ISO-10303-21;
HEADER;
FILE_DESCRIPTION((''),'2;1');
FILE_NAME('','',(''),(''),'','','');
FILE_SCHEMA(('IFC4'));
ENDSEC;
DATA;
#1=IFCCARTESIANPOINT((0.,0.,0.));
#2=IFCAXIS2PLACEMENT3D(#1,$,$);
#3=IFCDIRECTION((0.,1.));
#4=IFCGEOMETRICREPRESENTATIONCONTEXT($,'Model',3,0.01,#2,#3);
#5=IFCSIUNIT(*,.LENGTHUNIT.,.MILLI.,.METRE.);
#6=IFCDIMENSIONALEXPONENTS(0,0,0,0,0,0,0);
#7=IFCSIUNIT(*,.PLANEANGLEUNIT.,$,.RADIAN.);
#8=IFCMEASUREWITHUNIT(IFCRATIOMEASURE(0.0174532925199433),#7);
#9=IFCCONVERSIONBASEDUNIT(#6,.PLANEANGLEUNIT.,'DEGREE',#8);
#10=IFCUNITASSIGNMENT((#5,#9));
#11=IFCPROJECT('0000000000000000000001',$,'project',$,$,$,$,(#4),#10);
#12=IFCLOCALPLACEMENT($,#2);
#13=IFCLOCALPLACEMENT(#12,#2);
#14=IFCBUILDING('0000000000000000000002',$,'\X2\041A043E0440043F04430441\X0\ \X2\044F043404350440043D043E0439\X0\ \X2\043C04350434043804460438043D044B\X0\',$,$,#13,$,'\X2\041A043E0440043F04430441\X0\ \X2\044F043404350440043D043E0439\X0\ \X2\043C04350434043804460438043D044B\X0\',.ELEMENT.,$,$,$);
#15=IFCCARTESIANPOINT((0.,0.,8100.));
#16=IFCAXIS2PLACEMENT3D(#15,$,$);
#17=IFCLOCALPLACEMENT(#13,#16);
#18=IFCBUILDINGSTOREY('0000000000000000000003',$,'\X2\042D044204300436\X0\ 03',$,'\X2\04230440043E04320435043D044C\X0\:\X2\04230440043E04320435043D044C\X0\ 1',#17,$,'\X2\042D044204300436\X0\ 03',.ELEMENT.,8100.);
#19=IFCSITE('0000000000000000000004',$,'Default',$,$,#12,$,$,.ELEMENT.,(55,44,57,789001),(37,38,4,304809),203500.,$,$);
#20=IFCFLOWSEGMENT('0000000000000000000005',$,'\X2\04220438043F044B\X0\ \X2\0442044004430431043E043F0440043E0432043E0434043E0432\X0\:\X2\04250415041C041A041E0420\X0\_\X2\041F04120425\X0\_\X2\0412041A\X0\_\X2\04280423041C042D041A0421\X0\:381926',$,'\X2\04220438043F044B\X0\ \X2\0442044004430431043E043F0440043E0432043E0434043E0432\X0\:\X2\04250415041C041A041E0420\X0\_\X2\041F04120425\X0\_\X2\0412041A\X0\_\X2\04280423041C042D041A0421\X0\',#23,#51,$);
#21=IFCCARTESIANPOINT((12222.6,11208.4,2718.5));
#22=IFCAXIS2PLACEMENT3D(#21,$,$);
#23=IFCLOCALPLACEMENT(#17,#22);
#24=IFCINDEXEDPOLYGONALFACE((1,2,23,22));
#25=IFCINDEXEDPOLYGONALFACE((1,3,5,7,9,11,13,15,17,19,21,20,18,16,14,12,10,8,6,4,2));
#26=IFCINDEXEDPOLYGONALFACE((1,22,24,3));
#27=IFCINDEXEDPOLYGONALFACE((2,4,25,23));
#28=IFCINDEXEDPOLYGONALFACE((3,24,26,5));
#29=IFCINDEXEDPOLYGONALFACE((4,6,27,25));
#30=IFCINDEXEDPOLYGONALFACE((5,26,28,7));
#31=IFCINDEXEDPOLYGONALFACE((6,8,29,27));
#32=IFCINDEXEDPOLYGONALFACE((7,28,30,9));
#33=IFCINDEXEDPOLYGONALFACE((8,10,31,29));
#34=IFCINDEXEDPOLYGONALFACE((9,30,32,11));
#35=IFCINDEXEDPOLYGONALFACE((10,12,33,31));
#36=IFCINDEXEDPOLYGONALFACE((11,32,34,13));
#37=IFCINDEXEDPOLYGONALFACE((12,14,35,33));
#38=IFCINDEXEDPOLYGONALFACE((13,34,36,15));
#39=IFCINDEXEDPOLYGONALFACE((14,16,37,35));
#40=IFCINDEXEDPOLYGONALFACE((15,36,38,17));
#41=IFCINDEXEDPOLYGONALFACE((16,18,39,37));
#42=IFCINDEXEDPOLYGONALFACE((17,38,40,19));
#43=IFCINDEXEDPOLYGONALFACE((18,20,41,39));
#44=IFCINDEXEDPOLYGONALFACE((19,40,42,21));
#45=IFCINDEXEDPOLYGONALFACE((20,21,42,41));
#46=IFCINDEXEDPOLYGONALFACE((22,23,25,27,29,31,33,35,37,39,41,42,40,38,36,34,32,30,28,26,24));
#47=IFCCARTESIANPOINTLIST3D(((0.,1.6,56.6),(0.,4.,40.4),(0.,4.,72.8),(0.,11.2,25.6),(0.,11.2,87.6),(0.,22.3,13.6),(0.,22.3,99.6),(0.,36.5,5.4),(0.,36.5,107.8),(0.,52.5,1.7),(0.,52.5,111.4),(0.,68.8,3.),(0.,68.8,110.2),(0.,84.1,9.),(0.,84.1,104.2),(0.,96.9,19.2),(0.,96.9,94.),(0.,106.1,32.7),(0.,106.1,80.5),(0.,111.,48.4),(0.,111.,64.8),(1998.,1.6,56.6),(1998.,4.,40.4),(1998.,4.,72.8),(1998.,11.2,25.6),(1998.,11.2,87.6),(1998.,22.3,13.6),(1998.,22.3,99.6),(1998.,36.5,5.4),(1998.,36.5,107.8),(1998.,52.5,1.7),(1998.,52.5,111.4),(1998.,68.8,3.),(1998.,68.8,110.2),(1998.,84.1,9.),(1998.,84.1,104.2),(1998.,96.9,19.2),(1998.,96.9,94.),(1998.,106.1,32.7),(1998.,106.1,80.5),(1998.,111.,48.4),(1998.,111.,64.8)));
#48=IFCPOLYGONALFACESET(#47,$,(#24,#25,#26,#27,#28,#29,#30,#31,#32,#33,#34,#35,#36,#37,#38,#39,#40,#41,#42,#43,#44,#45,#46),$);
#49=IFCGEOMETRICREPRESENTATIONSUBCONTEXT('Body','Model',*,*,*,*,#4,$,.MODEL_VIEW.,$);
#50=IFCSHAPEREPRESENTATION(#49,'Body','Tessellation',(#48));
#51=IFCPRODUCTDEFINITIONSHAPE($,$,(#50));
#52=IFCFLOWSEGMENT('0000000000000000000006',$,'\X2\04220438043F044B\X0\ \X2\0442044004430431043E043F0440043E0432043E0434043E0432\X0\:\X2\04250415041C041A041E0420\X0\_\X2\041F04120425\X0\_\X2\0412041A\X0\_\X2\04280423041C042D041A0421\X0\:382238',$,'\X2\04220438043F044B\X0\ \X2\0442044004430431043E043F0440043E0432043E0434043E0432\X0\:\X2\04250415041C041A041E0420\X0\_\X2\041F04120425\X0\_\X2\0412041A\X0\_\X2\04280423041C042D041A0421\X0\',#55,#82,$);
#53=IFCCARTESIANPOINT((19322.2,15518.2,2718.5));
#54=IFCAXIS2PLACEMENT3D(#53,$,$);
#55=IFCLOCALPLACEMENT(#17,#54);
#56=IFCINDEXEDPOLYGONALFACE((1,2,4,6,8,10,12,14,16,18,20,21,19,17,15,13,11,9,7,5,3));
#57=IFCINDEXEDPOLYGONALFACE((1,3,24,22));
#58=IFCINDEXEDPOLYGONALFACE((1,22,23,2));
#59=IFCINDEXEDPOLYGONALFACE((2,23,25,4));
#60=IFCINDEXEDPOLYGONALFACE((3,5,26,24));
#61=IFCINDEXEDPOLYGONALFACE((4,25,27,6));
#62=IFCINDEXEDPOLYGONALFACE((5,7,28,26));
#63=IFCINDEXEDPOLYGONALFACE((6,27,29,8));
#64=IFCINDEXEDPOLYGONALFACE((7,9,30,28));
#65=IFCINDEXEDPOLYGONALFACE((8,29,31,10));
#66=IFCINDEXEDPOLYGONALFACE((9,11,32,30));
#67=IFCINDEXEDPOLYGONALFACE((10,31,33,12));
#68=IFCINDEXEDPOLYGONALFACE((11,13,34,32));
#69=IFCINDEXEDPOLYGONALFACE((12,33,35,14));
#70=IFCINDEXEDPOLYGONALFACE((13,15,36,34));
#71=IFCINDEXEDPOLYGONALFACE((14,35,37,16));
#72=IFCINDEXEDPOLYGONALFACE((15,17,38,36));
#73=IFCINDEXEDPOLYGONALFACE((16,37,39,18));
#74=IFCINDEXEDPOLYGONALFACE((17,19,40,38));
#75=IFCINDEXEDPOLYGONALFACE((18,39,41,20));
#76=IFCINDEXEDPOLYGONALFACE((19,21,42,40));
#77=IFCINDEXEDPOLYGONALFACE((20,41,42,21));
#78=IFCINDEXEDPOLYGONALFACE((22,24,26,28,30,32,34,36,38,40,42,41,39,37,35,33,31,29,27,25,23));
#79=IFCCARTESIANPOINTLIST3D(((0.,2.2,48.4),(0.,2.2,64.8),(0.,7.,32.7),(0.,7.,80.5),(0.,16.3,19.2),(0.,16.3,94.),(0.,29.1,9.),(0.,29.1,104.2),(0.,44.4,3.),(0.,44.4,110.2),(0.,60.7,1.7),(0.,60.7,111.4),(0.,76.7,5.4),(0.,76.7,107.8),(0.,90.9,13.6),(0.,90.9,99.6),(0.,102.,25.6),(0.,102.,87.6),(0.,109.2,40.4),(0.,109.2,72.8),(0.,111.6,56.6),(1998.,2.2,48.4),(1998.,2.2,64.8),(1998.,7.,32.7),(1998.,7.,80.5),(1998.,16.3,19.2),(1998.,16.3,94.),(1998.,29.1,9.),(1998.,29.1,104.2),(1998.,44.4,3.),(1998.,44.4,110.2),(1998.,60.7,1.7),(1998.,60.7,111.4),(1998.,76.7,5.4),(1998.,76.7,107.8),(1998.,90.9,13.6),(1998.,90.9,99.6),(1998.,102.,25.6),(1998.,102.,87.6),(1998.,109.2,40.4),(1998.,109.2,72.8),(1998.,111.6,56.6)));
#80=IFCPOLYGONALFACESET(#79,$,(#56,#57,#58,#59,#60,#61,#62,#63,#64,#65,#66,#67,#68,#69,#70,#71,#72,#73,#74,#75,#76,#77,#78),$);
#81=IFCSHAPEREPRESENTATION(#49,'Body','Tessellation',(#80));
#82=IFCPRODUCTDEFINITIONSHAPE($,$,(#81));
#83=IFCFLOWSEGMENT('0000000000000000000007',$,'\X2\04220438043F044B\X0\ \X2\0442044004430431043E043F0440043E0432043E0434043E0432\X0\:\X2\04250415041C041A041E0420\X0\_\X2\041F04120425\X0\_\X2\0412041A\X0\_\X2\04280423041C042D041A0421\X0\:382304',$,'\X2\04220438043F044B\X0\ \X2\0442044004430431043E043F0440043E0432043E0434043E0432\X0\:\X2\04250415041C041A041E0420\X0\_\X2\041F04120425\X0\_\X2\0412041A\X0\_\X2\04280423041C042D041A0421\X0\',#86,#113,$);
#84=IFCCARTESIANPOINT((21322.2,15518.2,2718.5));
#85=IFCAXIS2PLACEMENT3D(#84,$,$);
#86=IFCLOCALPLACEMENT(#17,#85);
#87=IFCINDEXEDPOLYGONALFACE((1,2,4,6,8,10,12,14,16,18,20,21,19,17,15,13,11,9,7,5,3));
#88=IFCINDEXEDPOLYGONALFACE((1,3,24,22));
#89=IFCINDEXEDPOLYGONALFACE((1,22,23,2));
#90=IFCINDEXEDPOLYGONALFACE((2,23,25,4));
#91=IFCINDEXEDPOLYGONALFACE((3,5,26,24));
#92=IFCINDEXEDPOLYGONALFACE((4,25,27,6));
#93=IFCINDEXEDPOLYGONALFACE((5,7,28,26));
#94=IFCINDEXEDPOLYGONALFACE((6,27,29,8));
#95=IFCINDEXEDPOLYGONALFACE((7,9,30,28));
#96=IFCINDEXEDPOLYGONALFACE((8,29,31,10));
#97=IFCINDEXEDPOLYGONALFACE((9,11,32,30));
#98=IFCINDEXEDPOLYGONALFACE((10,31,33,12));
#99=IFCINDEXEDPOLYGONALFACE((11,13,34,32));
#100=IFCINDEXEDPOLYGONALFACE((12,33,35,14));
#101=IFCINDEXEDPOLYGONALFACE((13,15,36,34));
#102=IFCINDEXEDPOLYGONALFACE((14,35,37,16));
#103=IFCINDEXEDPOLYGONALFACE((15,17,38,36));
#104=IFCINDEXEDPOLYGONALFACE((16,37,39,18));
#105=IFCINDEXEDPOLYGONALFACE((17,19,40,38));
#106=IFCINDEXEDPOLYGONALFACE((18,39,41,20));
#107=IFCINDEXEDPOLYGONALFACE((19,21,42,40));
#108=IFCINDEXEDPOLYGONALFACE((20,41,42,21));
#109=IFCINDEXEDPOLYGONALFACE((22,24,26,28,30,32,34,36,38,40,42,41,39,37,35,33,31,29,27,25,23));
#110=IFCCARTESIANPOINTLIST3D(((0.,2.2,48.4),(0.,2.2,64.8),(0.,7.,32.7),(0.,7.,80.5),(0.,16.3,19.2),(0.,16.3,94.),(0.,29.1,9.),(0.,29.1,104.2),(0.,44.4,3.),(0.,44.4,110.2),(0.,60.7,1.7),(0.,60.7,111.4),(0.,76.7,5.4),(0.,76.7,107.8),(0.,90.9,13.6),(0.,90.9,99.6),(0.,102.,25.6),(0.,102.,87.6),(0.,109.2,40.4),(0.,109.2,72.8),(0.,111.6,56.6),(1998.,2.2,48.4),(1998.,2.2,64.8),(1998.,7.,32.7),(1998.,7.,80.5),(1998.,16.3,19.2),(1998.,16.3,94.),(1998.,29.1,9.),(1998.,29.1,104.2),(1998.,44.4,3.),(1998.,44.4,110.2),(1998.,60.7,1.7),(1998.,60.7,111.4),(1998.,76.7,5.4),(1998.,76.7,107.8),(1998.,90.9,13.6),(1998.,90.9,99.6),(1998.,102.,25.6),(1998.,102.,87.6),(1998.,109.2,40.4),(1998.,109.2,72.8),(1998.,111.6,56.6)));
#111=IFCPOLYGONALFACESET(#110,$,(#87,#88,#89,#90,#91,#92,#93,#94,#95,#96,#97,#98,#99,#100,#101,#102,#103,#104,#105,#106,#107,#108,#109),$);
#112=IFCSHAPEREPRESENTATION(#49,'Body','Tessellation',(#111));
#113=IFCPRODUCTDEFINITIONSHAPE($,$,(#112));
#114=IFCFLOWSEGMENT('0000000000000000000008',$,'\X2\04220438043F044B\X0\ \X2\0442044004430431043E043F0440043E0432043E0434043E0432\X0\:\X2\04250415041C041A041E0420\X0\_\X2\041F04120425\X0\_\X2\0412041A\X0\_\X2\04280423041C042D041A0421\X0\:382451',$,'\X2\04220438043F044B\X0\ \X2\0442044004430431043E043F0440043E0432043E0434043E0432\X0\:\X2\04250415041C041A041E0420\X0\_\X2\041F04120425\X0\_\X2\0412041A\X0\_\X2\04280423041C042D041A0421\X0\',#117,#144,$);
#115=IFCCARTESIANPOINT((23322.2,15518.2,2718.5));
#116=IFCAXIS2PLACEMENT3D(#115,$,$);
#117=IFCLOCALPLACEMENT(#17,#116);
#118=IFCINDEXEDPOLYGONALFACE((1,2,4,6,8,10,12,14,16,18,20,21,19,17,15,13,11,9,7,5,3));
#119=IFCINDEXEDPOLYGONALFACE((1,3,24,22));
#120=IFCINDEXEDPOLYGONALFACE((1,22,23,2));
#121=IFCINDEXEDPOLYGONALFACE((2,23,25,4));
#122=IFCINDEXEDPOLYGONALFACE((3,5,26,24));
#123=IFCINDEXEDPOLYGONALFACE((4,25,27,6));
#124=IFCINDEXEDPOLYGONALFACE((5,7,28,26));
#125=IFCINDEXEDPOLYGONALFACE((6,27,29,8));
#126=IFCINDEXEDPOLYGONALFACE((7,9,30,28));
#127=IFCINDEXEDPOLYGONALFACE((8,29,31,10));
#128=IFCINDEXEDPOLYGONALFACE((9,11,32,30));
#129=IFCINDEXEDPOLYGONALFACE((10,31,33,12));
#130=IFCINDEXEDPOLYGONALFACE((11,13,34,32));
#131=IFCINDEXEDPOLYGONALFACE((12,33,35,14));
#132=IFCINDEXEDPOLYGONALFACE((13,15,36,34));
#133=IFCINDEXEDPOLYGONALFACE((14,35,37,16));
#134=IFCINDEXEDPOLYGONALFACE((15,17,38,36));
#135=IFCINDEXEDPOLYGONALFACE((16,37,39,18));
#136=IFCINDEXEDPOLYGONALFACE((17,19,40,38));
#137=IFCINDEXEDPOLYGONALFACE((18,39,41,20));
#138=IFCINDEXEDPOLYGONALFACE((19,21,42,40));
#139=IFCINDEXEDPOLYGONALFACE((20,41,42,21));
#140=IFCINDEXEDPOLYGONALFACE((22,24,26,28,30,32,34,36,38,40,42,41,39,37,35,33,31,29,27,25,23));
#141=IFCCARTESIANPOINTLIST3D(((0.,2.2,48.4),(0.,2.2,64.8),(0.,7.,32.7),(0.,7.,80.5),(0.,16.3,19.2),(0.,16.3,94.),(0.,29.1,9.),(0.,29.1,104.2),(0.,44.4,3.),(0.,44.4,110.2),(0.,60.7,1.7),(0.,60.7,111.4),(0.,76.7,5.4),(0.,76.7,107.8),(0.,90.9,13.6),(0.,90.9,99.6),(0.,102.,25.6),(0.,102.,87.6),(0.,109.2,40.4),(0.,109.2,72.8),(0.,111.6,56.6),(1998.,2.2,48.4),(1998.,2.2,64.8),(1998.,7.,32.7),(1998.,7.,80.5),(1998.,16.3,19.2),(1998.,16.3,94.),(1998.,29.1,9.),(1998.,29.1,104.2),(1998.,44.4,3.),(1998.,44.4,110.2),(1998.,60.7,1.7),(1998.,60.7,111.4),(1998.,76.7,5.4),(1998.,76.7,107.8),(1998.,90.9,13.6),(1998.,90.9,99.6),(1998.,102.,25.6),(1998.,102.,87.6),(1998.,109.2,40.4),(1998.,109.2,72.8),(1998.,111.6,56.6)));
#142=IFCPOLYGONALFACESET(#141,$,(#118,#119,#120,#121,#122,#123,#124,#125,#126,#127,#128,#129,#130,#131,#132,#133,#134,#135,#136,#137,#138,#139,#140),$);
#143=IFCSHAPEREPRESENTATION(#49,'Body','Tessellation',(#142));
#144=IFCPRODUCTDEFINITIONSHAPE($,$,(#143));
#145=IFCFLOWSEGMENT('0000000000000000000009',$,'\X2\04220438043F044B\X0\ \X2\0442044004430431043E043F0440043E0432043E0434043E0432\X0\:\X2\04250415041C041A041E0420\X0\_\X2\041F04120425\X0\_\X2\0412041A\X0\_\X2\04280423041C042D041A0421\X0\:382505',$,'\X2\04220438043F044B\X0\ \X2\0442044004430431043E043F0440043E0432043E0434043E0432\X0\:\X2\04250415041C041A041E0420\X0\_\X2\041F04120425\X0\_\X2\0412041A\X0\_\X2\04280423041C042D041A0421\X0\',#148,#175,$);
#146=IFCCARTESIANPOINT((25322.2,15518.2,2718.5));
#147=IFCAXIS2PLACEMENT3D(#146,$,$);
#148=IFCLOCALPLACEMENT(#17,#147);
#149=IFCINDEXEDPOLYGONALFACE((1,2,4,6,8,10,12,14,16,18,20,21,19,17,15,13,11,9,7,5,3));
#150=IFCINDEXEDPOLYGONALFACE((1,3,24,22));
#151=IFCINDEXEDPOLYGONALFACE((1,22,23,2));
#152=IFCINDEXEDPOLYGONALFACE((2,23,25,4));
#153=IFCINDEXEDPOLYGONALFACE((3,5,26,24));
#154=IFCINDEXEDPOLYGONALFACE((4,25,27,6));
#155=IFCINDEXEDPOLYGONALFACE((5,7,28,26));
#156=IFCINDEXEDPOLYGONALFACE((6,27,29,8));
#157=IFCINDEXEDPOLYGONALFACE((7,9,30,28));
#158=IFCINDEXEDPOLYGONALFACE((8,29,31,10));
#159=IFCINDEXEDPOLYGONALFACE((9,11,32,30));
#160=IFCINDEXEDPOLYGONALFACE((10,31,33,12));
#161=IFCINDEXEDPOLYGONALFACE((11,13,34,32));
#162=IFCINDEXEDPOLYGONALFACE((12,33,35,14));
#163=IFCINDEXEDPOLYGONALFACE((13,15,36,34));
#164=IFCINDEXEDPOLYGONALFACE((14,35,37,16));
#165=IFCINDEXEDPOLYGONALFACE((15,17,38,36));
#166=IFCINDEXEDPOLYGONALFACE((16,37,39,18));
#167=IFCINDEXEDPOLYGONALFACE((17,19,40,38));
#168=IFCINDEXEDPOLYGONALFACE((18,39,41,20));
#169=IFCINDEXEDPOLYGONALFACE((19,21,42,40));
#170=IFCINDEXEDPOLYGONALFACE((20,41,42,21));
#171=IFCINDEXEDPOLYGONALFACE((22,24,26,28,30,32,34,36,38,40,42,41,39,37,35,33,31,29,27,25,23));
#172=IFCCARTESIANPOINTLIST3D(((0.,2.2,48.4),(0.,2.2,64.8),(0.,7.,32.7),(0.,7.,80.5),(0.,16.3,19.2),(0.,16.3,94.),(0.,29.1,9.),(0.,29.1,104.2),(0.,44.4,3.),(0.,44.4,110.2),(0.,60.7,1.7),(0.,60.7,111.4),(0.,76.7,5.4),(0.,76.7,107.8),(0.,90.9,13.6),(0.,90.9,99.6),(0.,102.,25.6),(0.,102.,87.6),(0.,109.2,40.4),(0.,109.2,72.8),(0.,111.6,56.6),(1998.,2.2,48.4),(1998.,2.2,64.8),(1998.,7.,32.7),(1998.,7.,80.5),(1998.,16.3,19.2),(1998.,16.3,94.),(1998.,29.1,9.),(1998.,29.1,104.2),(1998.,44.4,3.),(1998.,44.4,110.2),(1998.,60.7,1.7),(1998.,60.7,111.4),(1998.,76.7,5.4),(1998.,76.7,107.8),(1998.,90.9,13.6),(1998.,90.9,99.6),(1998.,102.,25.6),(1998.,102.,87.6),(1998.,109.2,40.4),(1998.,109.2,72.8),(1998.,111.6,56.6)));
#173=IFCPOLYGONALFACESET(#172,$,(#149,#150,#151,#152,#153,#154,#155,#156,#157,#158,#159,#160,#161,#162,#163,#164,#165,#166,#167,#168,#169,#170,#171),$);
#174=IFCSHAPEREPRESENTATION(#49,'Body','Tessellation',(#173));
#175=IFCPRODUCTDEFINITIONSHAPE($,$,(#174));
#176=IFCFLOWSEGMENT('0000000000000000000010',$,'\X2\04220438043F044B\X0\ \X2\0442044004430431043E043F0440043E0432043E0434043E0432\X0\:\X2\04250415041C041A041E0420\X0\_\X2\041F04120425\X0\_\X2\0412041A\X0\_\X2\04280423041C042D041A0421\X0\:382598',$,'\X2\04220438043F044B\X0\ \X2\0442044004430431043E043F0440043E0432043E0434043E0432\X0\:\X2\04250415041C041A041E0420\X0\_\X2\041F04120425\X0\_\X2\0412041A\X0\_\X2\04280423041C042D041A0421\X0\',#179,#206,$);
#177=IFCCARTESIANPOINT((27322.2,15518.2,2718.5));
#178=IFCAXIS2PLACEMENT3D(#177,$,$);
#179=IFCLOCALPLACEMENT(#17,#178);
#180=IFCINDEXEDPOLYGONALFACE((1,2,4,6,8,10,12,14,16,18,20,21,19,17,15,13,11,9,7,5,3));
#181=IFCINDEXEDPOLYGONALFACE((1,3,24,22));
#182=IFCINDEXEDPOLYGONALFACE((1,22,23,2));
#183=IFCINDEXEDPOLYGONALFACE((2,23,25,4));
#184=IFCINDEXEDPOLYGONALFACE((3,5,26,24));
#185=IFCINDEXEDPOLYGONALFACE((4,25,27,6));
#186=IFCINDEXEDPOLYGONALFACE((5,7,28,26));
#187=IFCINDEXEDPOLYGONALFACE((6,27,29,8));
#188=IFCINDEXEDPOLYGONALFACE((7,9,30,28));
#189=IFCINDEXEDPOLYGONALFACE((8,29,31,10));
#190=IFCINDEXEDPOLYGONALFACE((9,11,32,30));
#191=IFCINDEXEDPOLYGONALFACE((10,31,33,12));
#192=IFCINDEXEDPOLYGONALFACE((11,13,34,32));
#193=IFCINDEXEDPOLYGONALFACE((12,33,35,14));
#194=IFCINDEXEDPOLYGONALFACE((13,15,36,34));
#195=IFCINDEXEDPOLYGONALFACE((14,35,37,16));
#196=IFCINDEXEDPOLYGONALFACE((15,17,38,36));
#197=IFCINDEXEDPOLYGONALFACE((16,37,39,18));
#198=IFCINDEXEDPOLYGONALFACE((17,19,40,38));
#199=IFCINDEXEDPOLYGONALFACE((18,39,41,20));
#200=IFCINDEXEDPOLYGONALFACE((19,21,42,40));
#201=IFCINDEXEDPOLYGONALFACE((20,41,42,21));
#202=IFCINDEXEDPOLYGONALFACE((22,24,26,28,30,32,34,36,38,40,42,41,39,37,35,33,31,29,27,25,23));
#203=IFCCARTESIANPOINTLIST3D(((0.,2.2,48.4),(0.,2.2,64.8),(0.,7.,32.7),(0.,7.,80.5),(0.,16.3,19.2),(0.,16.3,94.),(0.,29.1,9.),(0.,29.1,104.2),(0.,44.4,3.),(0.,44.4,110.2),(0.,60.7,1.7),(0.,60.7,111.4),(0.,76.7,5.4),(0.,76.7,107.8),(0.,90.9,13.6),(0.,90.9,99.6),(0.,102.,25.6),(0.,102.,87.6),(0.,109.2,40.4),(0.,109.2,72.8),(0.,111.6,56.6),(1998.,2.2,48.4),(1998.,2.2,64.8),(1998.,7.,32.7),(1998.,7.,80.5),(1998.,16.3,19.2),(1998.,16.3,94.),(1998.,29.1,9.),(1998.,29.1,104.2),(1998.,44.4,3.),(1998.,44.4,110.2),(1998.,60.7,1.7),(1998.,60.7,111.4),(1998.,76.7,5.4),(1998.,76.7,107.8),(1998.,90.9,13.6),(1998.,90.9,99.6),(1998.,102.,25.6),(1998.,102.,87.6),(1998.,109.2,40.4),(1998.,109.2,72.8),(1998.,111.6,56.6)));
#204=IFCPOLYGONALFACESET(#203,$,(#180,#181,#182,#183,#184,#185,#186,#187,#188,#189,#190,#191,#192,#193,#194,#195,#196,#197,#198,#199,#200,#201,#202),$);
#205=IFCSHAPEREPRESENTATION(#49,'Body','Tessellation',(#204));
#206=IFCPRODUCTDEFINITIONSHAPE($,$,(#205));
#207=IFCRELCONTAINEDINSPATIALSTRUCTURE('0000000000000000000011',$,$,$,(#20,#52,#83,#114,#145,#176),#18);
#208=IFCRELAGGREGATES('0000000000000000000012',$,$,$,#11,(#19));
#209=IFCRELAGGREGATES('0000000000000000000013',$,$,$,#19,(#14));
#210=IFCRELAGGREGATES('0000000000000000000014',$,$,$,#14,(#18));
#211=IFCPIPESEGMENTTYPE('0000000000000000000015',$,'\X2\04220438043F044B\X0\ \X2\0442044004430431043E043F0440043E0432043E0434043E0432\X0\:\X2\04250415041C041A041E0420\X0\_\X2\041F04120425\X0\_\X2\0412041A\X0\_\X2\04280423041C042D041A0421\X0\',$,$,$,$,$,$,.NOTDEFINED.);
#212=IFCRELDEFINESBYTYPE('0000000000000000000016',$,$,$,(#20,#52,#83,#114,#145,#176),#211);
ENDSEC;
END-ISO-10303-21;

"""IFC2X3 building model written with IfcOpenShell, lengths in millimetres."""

from ifc_helpers import new_model, entity, si_unit, converted_unit, direction, frame, frame_2d, origin, origin_2d_with_axis, place, context, subcontext, project, spatial, circle, extrude, type_object, element, save


model = new_model("IFC2X3")

# Units and contexts
model_context = context("Model", 3, precision=0.01, world=origin(), true_north=direction((0.0, 1.0)))
body_context = subcontext(model_context, "Body", "Model", "MODEL_VIEW")
ifc_project = project(units=[si_unit("LENGTHUNIT", "METRE", prefix="MILLI"), converted_unit("PLANEANGLEUNIT", "DEGREE", entity("IfcRatioMeasure", 0.0174532925199433), si_unit("PLANEANGLEUNIT", "RADIAN"), dimensions=[0, 0, 0, 0, 0, 0, 0])], contexts=[model_context])

# Site, building, storey
site_placement = place(None, frame((0.0, 0.0, 0.0)))
site = spatial("IfcSite", under=ifc_project, at=site_placement, Name="Default", CompositionType="ELEMENT", RefLatitude=(55, 44, 57, 789001), RefLongitude=(37, 38, 4, 304809), RefElevation=203500.0)
building_placement = place(site_placement, origin())
building = spatial("IfcBuilding", under=site, at=building_placement, Name="Корпус ядерной медицины", LongName="Корпус ядерной медицины", CompositionType="ELEMENT")
storey_placement = place(building_placement, frame((0.0, 0.0, 8100.0)))
storey = spatial("IfcBuildingStorey", under=building, at=storey_placement, Name="Этаж 03", ObjectType="Уровень:Уровень 1", LongName="Этаж 03", CompositionType="ELEMENT", Elevation=8100.0)

# Flow segments
pipe_segment_type = type_object("IfcPipeSegmentType", Name="Типы трубопроводов:ХЕМКОР_ПВХ_ВК_ШУМЭКС", PredefinedType="NOTDEFINED")
for number, where, name in (
    (1, (12222.6, 11208.4, 2718.5), "Типы трубопроводов:ХЕМКОР_ПВХ_ВК_ШУМЭКС:381926"),
):
    element("IfcFlowSegment", number, at=place(storey_placement, frame(where)), inside=storey, type_object=pipe_segment_type, Name=name, ObjectType="Типы трубопроводов:ХЕМКОР_ПВХ_ВК_ШУМЭКС", context=body_context, shape_type="SweptSolid", body=[
        extrude(circle(Radius=55.0, at=origin_2d_with_axis()), frame((0.0, 56.6, 56.6), z_axis=(1.0, 0.0, 0.0), x_axis=(0.0, -1.0, 0.0)), (0.0, 0.0, 1.0), 1998.0),
    ])
flow_segment_1_placement = place(storey_placement, frame((19322.2, 15518.2, 2718.5)))
element("IfcFlowSegment", 2, at=flow_segment_1_placement, inside=storey, type_object=pipe_segment_type, Name="Типы трубопроводов:ХЕМКОР_ПВХ_ВК_ШУМЭКС:382238", ObjectType="Типы трубопроводов:ХЕМКОР_ПВХ_ВК_ШУМЭКС", context=body_context, shape_type="SweptSolid", body=[
    extrude(circle(Radius=55.0, at=frame_2d((0.0, 0.0), x_axis=(1.0, 0.0))), frame((0.0, 56.6, 56.6), z_axis=(1.0, 0.0, 0.0), x_axis=(0.0, 1.0, 0.0)), (0.0, 0.0, 1.0), 1998.0),
])
flow_segment_2_placement = place(storey_placement, frame((21322.2, 15518.2, 2718.5)))
element("IfcFlowSegment", 3, at=flow_segment_2_placement, inside=storey, type_object=pipe_segment_type, Name="Типы трубопроводов:ХЕМКОР_ПВХ_ВК_ШУМЭКС:382304", ObjectType="Типы трубопроводов:ХЕМКОР_ПВХ_ВК_ШУМЭКС", context=body_context, shape_type="SweptSolid", body=[
    extrude(circle(Radius=55.0, at=frame_2d((0.0, 0.0), x_axis=(1.0, 0.0))), frame((0.0, 56.6, 56.6), z_axis=(1.0, 0.0, 0.0), x_axis=(0.0, 1.0, 0.0)), (0.0, 0.0, 1.0), 1998.0),
])
flow_segment_3_placement = place(storey_placement, frame((23322.2, 15518.2, 2718.5)))
element("IfcFlowSegment", 4, at=flow_segment_3_placement, inside=storey, type_object=pipe_segment_type, Name="Типы трубопроводов:ХЕМКОР_ПВХ_ВК_ШУМЭКС:382451", ObjectType="Типы трубопроводов:ХЕМКОР_ПВХ_ВК_ШУМЭКС", context=body_context, shape_type="SweptSolid", body=[
    extrude(circle(Radius=55.0, at=frame_2d((0.0, 0.0), x_axis=(1.0, 0.0))), frame((0.0, 56.6, 56.6), z_axis=(1.0, 0.0, 0.0), x_axis=(0.0, 1.0, 0.0)), (0.0, 0.0, 1.0), 1998.0),
])
flow_segment_4_placement = place(storey_placement, frame((25322.2, 15518.2, 2718.5)))
element("IfcFlowSegment", 5, at=flow_segment_4_placement, inside=storey, type_object=pipe_segment_type, Name="Типы трубопроводов:ХЕМКОР_ПВХ_ВК_ШУМЭКС:382505", ObjectType="Типы трубопроводов:ХЕМКОР_ПВХ_ВК_ШУМЭКС", context=body_context, shape_type="SweptSolid", body=[
    extrude(circle(Radius=55.0, at=frame_2d((0.0, 0.0), x_axis=(1.0, 0.0))), frame((0.0, 56.6, 56.6), z_axis=(1.0, 0.0, 0.0), x_axis=(0.0, 1.0, 0.0)), (0.0, 0.0, 1.0), 1998.0),
])
flow_segment_5_placement = place(storey_placement, frame((27322.2, 15518.2, 2718.5)))
element("IfcFlowSegment", 6, at=flow_segment_5_placement, inside=storey, type_object=pipe_segment_type, Name="Типы трубопроводов:ХЕМКОР_ПВХ_ВК_ШУМЭКС:382598", ObjectType="Типы трубопроводов:ХЕМКОР_ПВХ_ВК_ШУМЭКС", context=body_context, shape_type="SweptSolid", body=[
    extrude(circle(Radius=55.0, at=frame_2d((0.0, 0.0), x_axis=(1.0, 0.0))), frame((0.0, 56.6, 56.6), z_axis=(1.0, 0.0, 0.0), x_axis=(0.0, 1.0, 0.0)), (0.0, 0.0, 1.0), 1998.0),
])

save(model, "model.ifc")
